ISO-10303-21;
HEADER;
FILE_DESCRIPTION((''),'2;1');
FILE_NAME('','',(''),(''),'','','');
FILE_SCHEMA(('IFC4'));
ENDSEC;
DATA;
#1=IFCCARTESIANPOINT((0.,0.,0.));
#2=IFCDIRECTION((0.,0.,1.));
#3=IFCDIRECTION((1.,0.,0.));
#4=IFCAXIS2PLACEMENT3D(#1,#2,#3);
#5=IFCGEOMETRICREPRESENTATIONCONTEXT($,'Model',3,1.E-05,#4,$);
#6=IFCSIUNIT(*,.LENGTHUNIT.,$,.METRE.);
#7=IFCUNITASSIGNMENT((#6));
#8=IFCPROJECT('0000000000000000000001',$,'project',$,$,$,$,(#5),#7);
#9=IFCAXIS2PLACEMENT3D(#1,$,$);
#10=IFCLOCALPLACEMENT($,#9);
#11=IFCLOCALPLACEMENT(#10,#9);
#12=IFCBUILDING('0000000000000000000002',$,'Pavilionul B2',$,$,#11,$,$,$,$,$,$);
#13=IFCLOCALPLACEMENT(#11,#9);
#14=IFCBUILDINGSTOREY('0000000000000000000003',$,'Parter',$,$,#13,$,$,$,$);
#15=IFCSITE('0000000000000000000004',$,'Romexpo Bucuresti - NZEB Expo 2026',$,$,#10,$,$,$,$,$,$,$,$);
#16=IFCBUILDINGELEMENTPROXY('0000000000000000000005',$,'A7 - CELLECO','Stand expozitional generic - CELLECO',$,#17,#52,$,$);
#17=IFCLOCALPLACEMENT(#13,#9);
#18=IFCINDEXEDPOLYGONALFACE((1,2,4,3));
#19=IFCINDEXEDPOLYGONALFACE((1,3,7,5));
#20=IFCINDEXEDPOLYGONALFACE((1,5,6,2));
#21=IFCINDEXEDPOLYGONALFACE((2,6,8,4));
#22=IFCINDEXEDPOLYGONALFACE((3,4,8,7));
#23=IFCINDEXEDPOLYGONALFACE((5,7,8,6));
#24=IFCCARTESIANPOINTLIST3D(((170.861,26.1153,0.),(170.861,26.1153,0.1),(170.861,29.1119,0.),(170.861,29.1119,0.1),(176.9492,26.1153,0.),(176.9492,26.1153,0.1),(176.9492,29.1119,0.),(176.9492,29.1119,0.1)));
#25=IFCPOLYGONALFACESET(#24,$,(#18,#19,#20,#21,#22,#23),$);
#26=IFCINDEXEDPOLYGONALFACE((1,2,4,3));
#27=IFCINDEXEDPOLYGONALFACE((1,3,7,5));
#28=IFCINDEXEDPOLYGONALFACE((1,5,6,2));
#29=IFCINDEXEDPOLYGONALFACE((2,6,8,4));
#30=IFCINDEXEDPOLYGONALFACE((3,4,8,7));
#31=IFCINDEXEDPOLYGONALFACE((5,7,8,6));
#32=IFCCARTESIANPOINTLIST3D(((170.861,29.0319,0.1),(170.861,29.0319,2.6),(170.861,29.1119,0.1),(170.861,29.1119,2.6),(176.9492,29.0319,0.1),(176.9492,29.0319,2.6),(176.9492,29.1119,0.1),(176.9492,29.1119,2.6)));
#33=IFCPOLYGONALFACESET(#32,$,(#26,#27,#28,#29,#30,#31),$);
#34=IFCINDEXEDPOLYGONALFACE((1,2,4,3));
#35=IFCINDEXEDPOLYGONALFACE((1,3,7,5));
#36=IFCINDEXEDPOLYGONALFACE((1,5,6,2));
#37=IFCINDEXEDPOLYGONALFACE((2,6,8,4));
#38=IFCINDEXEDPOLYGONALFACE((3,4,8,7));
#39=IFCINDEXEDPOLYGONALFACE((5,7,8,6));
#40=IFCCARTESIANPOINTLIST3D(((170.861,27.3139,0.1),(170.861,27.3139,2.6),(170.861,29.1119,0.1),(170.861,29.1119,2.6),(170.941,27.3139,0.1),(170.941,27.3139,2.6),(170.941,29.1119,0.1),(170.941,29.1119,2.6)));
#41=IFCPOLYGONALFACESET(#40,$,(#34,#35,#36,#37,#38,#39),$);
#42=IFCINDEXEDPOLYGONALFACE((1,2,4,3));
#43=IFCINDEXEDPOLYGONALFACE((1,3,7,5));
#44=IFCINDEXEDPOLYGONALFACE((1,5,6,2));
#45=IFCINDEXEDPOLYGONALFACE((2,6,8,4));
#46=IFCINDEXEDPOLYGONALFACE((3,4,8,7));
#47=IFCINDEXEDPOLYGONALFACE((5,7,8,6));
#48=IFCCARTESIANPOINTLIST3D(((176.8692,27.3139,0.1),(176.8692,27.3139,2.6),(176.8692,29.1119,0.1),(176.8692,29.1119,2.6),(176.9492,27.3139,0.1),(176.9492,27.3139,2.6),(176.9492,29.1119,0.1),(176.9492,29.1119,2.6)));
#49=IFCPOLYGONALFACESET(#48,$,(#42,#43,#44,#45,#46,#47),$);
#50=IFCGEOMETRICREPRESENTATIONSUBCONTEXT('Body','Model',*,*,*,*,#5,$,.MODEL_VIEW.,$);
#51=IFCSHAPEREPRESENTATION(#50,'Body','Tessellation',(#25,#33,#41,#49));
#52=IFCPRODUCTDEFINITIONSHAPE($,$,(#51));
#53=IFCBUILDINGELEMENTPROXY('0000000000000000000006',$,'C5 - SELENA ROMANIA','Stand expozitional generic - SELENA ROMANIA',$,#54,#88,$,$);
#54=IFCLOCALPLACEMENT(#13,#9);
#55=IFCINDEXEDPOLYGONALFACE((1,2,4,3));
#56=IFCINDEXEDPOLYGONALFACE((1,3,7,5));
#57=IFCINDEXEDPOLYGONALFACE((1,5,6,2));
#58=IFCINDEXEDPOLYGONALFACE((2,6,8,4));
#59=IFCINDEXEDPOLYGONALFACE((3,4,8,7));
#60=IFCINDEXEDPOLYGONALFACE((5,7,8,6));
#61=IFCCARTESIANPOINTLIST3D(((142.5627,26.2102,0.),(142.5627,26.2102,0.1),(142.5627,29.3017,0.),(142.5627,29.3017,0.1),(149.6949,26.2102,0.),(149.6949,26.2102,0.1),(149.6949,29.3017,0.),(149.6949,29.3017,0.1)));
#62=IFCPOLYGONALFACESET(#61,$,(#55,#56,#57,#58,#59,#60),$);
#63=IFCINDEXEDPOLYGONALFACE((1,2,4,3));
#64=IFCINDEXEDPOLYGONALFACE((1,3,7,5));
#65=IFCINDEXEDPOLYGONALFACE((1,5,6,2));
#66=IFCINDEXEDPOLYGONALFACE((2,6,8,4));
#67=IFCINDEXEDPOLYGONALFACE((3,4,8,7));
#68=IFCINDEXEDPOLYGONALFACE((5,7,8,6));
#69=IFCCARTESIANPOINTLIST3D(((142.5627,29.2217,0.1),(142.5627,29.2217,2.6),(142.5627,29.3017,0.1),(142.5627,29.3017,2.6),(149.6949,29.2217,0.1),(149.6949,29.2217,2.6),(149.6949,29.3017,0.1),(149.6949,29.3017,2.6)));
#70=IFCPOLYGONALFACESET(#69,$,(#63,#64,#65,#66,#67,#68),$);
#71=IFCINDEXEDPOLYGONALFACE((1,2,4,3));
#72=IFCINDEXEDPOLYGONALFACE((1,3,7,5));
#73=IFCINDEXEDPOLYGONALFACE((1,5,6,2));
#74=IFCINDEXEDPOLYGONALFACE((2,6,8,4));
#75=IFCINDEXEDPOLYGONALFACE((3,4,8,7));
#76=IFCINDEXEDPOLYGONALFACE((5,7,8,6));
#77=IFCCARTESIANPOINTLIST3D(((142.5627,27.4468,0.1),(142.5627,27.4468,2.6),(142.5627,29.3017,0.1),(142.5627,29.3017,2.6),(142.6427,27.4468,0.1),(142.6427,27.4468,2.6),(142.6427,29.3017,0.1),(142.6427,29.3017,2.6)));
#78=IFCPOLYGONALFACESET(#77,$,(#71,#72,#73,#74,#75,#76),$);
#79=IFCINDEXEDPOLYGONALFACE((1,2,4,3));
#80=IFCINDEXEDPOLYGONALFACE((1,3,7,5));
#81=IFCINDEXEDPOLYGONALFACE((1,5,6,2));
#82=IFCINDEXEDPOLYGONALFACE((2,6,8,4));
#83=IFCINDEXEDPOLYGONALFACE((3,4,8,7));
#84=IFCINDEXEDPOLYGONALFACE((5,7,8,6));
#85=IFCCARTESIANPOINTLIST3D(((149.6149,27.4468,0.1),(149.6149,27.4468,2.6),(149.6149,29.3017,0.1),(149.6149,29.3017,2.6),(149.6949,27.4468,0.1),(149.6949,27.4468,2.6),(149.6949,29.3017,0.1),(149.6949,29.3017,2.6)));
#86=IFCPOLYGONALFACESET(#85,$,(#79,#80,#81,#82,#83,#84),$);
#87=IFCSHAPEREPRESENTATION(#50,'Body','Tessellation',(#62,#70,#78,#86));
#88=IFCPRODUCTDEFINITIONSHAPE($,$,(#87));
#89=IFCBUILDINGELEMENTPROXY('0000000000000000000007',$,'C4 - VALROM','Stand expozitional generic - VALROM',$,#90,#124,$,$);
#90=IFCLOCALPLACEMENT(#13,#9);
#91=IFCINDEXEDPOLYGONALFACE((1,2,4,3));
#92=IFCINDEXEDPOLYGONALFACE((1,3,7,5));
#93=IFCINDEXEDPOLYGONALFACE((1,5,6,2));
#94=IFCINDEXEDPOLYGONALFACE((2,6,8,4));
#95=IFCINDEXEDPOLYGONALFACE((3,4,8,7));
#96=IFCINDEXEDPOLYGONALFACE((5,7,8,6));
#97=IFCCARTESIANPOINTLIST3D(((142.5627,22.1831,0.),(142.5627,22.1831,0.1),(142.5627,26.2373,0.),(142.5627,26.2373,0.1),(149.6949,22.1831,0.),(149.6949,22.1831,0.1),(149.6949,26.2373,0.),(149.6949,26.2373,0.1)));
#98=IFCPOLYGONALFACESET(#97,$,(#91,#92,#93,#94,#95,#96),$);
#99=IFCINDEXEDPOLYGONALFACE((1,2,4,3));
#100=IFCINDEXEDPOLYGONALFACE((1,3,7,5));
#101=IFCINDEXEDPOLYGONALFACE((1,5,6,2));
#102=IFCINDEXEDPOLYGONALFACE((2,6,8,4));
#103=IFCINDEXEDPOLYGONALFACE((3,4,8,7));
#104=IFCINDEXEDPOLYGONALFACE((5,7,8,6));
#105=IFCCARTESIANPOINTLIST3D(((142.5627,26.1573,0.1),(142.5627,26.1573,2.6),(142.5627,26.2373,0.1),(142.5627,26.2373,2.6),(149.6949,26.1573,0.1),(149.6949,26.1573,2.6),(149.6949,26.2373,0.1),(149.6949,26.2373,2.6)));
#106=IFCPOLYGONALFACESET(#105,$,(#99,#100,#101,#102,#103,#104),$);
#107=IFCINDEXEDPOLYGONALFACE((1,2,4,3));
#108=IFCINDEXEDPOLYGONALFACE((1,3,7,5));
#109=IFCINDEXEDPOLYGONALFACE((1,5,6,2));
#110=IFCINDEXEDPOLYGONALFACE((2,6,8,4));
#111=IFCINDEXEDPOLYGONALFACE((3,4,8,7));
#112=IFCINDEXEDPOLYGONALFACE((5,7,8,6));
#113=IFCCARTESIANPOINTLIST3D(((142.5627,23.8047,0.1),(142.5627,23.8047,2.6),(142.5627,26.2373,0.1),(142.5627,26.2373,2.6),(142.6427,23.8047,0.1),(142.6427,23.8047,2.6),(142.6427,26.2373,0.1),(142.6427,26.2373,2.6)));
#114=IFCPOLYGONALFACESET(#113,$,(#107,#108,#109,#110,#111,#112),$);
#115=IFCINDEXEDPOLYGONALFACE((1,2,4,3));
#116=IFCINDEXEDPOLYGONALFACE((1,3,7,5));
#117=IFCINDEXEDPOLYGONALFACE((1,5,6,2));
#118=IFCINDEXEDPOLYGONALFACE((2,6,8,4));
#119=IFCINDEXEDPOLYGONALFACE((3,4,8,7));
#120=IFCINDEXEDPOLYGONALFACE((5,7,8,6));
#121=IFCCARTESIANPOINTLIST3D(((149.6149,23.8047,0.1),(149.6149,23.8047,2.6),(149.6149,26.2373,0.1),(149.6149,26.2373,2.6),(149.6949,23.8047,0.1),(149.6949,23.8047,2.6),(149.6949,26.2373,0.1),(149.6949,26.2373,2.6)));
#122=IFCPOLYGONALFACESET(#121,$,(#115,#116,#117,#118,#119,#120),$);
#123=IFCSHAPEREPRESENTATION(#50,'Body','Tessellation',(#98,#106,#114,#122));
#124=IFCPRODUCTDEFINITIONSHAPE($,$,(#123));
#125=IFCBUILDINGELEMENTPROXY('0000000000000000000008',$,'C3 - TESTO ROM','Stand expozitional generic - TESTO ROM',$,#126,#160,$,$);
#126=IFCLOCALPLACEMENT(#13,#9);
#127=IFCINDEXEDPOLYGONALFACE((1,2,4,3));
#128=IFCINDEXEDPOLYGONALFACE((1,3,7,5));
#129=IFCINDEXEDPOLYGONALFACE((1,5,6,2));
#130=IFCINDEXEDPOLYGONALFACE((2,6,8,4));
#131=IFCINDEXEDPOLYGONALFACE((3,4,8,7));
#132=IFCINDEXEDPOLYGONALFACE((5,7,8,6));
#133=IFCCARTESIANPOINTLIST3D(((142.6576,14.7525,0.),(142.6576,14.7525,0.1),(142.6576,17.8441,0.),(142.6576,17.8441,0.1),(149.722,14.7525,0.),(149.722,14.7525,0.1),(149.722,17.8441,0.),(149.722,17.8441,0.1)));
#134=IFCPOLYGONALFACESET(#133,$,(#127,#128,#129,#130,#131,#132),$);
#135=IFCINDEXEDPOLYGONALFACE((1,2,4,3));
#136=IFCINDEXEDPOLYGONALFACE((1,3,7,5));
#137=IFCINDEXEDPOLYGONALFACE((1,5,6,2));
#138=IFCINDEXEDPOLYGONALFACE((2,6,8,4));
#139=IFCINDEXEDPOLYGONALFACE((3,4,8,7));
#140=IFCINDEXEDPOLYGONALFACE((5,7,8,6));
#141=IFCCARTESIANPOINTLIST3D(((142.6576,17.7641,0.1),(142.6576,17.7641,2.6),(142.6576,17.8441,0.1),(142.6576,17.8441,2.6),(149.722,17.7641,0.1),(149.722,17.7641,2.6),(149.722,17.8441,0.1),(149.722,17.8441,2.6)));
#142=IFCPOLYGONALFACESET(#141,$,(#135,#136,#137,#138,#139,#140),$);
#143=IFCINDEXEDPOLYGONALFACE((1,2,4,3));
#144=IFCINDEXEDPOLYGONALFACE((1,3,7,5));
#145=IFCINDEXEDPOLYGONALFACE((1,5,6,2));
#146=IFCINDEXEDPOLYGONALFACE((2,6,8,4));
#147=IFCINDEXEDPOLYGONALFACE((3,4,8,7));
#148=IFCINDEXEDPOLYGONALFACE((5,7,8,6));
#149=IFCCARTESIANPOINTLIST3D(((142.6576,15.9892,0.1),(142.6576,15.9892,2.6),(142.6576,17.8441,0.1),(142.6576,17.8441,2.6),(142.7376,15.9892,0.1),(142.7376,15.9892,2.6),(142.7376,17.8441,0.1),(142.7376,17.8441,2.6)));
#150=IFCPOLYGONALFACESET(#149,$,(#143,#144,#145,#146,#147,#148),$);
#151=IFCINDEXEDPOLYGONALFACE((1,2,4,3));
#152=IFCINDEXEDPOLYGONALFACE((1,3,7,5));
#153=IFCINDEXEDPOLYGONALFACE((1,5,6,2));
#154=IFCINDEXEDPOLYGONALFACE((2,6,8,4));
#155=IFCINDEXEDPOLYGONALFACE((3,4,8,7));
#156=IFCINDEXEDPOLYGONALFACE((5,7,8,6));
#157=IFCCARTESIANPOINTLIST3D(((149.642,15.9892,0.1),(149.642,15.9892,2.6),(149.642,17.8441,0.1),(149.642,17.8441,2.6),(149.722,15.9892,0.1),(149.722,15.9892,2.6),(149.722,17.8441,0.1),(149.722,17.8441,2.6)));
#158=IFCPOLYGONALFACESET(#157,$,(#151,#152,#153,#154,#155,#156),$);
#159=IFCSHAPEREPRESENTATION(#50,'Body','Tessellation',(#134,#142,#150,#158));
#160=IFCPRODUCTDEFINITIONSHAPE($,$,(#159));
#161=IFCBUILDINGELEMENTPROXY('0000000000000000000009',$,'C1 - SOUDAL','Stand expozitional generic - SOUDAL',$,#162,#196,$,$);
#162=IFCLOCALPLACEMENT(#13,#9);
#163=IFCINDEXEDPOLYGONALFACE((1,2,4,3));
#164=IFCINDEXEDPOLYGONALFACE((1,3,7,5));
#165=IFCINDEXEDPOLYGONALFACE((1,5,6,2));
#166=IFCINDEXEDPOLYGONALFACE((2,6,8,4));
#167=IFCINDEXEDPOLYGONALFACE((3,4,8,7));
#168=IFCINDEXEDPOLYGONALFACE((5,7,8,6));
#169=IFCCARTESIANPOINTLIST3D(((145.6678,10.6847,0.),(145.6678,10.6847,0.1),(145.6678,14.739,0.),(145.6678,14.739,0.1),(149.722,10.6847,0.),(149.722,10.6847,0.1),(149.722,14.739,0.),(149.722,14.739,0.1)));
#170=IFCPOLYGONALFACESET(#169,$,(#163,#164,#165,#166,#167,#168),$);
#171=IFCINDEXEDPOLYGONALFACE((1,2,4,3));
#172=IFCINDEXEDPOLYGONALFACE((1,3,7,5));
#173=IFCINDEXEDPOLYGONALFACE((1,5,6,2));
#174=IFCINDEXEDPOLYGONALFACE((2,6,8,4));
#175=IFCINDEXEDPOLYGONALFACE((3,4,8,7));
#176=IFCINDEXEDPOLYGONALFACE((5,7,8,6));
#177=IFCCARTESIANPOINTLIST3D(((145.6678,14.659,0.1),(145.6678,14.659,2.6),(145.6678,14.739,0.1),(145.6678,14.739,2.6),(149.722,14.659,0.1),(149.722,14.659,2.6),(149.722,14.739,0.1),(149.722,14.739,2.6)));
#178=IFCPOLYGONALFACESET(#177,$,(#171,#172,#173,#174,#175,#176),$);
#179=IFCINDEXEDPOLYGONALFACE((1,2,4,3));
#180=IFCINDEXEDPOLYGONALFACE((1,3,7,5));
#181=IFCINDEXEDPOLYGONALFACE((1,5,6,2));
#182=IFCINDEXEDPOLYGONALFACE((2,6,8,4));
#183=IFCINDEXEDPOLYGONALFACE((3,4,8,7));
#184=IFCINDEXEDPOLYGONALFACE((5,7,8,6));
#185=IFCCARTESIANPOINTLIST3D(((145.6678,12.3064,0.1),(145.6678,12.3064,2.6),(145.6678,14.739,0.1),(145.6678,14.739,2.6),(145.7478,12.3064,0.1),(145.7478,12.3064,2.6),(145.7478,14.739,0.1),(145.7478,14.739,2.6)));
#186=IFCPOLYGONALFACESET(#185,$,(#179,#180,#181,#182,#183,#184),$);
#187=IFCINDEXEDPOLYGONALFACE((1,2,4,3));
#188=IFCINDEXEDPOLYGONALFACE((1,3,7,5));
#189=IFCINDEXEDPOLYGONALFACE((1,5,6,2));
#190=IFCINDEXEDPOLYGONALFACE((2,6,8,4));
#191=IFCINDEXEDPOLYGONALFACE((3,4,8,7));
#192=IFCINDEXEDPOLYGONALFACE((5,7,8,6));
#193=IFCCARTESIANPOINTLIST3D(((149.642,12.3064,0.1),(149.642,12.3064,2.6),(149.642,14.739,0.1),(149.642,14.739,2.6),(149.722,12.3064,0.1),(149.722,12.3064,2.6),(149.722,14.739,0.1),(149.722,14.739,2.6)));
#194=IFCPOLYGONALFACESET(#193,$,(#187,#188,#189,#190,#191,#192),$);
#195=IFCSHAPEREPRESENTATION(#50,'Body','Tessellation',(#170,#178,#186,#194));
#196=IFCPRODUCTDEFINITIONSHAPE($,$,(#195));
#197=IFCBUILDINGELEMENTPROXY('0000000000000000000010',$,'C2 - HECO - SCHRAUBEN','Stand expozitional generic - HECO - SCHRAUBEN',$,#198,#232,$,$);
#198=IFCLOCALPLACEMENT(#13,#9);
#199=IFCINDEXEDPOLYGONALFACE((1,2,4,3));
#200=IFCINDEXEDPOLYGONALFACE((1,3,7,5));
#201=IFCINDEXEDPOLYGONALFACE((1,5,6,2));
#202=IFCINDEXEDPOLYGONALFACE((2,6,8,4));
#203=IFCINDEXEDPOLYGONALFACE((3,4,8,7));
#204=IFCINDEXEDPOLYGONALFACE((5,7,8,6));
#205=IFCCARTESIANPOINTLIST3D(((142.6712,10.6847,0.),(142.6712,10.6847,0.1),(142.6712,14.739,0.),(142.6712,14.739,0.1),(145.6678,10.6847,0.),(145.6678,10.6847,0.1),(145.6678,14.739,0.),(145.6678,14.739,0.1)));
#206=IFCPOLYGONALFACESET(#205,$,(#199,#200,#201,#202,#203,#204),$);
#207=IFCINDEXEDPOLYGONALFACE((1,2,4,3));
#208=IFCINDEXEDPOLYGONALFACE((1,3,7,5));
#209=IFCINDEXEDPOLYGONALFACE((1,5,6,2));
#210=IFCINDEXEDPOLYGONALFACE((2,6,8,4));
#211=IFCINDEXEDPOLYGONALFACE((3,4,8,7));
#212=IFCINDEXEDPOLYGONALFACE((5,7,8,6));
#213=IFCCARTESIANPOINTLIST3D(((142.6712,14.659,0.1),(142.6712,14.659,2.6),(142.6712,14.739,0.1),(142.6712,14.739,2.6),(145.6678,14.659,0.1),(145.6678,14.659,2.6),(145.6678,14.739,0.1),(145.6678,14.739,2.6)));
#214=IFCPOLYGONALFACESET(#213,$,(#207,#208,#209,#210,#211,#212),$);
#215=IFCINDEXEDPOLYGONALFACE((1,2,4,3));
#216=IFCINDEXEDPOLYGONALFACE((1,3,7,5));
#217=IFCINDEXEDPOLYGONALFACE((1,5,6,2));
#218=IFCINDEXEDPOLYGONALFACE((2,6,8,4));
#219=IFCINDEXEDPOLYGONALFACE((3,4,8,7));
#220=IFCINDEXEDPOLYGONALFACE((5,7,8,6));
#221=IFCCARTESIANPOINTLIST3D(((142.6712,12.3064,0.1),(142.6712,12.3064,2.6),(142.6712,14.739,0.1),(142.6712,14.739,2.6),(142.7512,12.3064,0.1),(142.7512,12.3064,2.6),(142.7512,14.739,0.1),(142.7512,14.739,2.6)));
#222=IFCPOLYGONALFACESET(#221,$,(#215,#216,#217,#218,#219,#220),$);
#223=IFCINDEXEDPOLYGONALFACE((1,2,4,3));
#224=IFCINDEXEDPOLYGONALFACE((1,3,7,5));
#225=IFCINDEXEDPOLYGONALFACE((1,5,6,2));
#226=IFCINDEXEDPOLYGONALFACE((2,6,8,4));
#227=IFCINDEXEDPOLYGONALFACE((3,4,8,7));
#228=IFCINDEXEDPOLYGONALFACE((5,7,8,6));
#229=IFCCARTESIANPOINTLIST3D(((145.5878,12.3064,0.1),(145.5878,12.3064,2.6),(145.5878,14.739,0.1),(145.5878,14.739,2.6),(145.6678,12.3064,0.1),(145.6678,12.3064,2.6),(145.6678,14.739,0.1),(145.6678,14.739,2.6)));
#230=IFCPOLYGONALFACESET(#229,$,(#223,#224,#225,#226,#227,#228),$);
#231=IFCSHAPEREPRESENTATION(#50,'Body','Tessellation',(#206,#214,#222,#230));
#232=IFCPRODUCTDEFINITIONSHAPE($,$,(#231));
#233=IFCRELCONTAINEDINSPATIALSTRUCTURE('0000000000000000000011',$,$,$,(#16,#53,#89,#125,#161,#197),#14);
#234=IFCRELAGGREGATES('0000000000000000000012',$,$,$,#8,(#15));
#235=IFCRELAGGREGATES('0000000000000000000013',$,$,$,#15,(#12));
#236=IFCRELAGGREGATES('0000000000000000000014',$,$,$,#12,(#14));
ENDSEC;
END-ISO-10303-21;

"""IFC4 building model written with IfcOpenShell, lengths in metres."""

from ifc_helpers import new_model, si_unit, frame, frame_2d, origin, origin_with_axes, place, context, subcontext, project, spatial, rectangle, extrude, element, save


model = new_model("IFC4")

# Units and contexts
model_context = context("Model", 3, precision=1e-05, world=origin_with_axes())
body_context = subcontext(model_context, "Body", "Model", "MODEL_VIEW")
ifc_project = project(units=[si_unit("LENGTHUNIT", "METRE")], contexts=[model_context])

# Site, building, storey
site_placement = place(None, origin())
site = spatial("IfcSite", under=ifc_project, at=site_placement, Name="Romexpo Bucuresti - NZEB Expo 2026")
building_placement = place(site_placement, origin())
building = spatial("IfcBuilding", under=site, at=building_placement, Name="Pavilionul B2")
storey_placement = place(building_placement, origin())
storey = spatial("IfcBuildingStorey", under=building, at=storey_placement, Name="Parter")

# Building element proxies
proxy_1_placement = place(storey_placement, frame((170.861, 26.1153, 0.0), z_axis=(0.0, 0.0, 1.0), x_axis=(1.0, 0.0, 0.0)))
element("IfcBuildingElementProxy", 1, at=proxy_1_placement, inside=storey, Name="A7 - CELLECO", Description="Stand expozitional generic - CELLECO", context=body_context, shape_type="SweptSolid", body=[
    extrude(rectangle(XDim=6.0881, YDim=2.9966, at=frame_2d((3.0441, 1.4983))), origin(), (0.0, 0.0, 1.0), 0.1),
    extrude(rectangle(XDim=6.0881, YDim=0.08, at=frame_2d((3.0441, 2.9566))), frame((0.0, 0.0, 0.1)), (0.0, 0.0, 1.0), 2.5),
    extrude(rectangle(XDim=0.08, YDim=1.798, at=frame_2d((0.04, 2.0976))), frame((0.0, 0.0, 0.1)), (0.0, 0.0, 1.0), 2.5),
    extrude(rectangle(XDim=0.08, YDim=1.798, at=frame_2d((6.0481, 2.0976))), frame((0.0, 0.0, 0.1)), (0.0, 0.0, 1.0), 2.5),
])
proxy_2_placement = place(storey_placement, frame((142.5627, 26.2102, 0.0), z_axis=(0.0, 0.0, 1.0), x_axis=(1.0, 0.0, 0.0)))
element("IfcBuildingElementProxy", 2, at=proxy_2_placement, inside=storey, Name="C5 - SELENA ROMANIA", Description="Stand expozitional generic - SELENA ROMANIA", context=body_context, shape_type="SweptSolid", body=[
    extrude(rectangle(XDim=7.1322, YDim=3.0915, at=frame_2d((3.5661, 1.5458))), origin(), (0.0, 0.0, 1.0), 0.1),
    extrude(rectangle(XDim=7.1322, YDim=0.08, at=frame_2d((3.5661, 3.0515))), frame((0.0, 0.0, 0.1)), (0.0, 0.0, 1.0), 2.5),
    extrude(rectangle(XDim=0.08, YDim=1.8549, at=frame_2d((0.04, 2.1641))), frame((0.0, 0.0, 0.1)), (0.0, 0.0, 1.0), 2.5),
    extrude(rectangle(XDim=0.08, YDim=1.8549, at=frame_2d((7.0922, 2.1641))), frame((0.0, 0.0, 0.1)), (0.0, 0.0, 1.0), 2.5),
])
proxy_3_placement = place(storey_placement, frame((142.5627, 22.1831, 0.0), z_axis=(0.0, 0.0, 1.0), x_axis=(1.0, 0.0, 0.0)))
element("IfcBuildingElementProxy", 3, at=proxy_3_placement, inside=storey, Name="C4 - VALROM", Description="Stand expozitional generic - VALROM", context=body_context, shape_type="SweptSolid", body=[
    extrude(rectangle(XDim=7.1322, YDim=4.0542, at=frame_2d((3.5661, 2.0271))), origin(), (0.0, 0.0, 1.0), 0.1),
    extrude(rectangle(XDim=7.1322, YDim=0.08, at=frame_2d((3.5661, 4.0142))), frame((0.0, 0.0, 0.1)), (0.0, 0.0, 1.0), 2.5),
    extrude(rectangle(XDim=0.08, YDim=2.4325, at=frame_2d((0.04, 2.838))), frame((0.0, 0.0, 0.1)), (0.0, 0.0, 1.0), 2.5),
    extrude(rectangle(XDim=0.08, YDim=2.4325, at=frame_2d((7.0922, 2.838))), frame((0.0, 0.0, 0.1)), (0.0, 0.0, 1.0), 2.5),
])
proxy_4_placement = place(storey_placement, frame((142.6576, 14.7525, 0.0), z_axis=(0.0, 0.0, 1.0), x_axis=(1.0, 0.0, 0.0)))
element("IfcBuildingElementProxy", 4, at=proxy_4_placement, inside=storey, Name="C3 - TESTO ROM", Description="Stand expozitional generic - TESTO ROM", context=body_context, shape_type="SweptSolid", body=[
    extrude(rectangle(XDim=7.0644, YDim=3.0915, at=frame_2d((3.5322, 1.5458))), origin(), (0.0, 0.0, 1.0), 0.1),
    extrude(rectangle(XDim=7.0644, YDim=0.08, at=frame_2d((3.5322, 3.0515))), frame((0.0, 0.0, 0.1)), (0.0, 0.0, 1.0), 2.5),
    extrude(rectangle(XDim=0.08, YDim=1.8549, at=frame_2d((0.04, 2.1641))), frame((0.0, 0.0, 0.1)), (0.0, 0.0, 1.0), 2.5),
    extrude(rectangle(XDim=0.08, YDim=1.8549, at=frame_2d((7.0244, 2.1641))), frame((0.0, 0.0, 0.1)), (0.0, 0.0, 1.0), 2.5),
])
proxy_5_placement = place(storey_placement, frame((145.6678, 10.6847, 0.0), z_axis=(0.0, 0.0, 1.0), x_axis=(1.0, 0.0, 0.0)))
element("IfcBuildingElementProxy", 5, at=proxy_5_placement, inside=storey, Name="C1 - SOUDAL", Description="Stand expozitional generic - SOUDAL", context=body_context, shape_type="SweptSolid", body=[
    extrude(rectangle(XDim=4.0542, YDim=4.0542, at=frame_2d((2.0271, 2.0271))), origin(), (0.0, 0.0, 1.0), 0.1),
    extrude(rectangle(XDim=4.0542, YDim=0.08, at=frame_2d((2.0271, 4.0142))), frame((0.0, 0.0, 0.1)), (0.0, 0.0, 1.0), 2.5),
    extrude(rectangle(XDim=0.08, YDim=2.4325, at=frame_2d((0.04, 2.838))), frame((0.0, 0.0, 0.1)), (0.0, 0.0, 1.0), 2.5),
    extrude(rectangle(XDim=0.08, YDim=2.4325, at=frame_2d((4.0142, 2.838))), frame((0.0, 0.0, 0.1)), (0.0, 0.0, 1.0), 2.5),
])
proxy_6_placement = place(storey_placement, frame((142.6712, 10.6847, 0.0), z_axis=(0.0, 0.0, 1.0), x_axis=(1.0, 0.0, 0.0)))
element("IfcBuildingElementProxy", 6, at=proxy_6_placement, inside=storey, Name="C2 - HECO - SCHRAUBEN", Description="Stand expozitional generic - HECO - SCHRAUBEN", context=body_context, shape_type="SweptSolid", body=[
    extrude(rectangle(XDim=2.9966, YDim=4.0542, at=frame_2d((1.4983, 2.0271))), origin(), (0.0, 0.0, 1.0), 0.1),
    extrude(rectangle(XDim=2.9966, YDim=0.08, at=frame_2d((1.4983, 4.0142))), frame((0.0, 0.0, 0.1)), (0.0, 0.0, 1.0), 2.5),
    extrude(rectangle(XDim=0.08, YDim=2.4325, at=frame_2d((0.04, 2.838))), frame((0.0, 0.0, 0.1)), (0.0, 0.0, 1.0), 2.5),
    extrude(rectangle(XDim=0.08, YDim=2.4325, at=frame_2d((2.9566, 2.838))), frame((0.0, 0.0, 0.1)), (0.0, 0.0, 1.0), 2.5),
])

save(model, "model.ifc")
